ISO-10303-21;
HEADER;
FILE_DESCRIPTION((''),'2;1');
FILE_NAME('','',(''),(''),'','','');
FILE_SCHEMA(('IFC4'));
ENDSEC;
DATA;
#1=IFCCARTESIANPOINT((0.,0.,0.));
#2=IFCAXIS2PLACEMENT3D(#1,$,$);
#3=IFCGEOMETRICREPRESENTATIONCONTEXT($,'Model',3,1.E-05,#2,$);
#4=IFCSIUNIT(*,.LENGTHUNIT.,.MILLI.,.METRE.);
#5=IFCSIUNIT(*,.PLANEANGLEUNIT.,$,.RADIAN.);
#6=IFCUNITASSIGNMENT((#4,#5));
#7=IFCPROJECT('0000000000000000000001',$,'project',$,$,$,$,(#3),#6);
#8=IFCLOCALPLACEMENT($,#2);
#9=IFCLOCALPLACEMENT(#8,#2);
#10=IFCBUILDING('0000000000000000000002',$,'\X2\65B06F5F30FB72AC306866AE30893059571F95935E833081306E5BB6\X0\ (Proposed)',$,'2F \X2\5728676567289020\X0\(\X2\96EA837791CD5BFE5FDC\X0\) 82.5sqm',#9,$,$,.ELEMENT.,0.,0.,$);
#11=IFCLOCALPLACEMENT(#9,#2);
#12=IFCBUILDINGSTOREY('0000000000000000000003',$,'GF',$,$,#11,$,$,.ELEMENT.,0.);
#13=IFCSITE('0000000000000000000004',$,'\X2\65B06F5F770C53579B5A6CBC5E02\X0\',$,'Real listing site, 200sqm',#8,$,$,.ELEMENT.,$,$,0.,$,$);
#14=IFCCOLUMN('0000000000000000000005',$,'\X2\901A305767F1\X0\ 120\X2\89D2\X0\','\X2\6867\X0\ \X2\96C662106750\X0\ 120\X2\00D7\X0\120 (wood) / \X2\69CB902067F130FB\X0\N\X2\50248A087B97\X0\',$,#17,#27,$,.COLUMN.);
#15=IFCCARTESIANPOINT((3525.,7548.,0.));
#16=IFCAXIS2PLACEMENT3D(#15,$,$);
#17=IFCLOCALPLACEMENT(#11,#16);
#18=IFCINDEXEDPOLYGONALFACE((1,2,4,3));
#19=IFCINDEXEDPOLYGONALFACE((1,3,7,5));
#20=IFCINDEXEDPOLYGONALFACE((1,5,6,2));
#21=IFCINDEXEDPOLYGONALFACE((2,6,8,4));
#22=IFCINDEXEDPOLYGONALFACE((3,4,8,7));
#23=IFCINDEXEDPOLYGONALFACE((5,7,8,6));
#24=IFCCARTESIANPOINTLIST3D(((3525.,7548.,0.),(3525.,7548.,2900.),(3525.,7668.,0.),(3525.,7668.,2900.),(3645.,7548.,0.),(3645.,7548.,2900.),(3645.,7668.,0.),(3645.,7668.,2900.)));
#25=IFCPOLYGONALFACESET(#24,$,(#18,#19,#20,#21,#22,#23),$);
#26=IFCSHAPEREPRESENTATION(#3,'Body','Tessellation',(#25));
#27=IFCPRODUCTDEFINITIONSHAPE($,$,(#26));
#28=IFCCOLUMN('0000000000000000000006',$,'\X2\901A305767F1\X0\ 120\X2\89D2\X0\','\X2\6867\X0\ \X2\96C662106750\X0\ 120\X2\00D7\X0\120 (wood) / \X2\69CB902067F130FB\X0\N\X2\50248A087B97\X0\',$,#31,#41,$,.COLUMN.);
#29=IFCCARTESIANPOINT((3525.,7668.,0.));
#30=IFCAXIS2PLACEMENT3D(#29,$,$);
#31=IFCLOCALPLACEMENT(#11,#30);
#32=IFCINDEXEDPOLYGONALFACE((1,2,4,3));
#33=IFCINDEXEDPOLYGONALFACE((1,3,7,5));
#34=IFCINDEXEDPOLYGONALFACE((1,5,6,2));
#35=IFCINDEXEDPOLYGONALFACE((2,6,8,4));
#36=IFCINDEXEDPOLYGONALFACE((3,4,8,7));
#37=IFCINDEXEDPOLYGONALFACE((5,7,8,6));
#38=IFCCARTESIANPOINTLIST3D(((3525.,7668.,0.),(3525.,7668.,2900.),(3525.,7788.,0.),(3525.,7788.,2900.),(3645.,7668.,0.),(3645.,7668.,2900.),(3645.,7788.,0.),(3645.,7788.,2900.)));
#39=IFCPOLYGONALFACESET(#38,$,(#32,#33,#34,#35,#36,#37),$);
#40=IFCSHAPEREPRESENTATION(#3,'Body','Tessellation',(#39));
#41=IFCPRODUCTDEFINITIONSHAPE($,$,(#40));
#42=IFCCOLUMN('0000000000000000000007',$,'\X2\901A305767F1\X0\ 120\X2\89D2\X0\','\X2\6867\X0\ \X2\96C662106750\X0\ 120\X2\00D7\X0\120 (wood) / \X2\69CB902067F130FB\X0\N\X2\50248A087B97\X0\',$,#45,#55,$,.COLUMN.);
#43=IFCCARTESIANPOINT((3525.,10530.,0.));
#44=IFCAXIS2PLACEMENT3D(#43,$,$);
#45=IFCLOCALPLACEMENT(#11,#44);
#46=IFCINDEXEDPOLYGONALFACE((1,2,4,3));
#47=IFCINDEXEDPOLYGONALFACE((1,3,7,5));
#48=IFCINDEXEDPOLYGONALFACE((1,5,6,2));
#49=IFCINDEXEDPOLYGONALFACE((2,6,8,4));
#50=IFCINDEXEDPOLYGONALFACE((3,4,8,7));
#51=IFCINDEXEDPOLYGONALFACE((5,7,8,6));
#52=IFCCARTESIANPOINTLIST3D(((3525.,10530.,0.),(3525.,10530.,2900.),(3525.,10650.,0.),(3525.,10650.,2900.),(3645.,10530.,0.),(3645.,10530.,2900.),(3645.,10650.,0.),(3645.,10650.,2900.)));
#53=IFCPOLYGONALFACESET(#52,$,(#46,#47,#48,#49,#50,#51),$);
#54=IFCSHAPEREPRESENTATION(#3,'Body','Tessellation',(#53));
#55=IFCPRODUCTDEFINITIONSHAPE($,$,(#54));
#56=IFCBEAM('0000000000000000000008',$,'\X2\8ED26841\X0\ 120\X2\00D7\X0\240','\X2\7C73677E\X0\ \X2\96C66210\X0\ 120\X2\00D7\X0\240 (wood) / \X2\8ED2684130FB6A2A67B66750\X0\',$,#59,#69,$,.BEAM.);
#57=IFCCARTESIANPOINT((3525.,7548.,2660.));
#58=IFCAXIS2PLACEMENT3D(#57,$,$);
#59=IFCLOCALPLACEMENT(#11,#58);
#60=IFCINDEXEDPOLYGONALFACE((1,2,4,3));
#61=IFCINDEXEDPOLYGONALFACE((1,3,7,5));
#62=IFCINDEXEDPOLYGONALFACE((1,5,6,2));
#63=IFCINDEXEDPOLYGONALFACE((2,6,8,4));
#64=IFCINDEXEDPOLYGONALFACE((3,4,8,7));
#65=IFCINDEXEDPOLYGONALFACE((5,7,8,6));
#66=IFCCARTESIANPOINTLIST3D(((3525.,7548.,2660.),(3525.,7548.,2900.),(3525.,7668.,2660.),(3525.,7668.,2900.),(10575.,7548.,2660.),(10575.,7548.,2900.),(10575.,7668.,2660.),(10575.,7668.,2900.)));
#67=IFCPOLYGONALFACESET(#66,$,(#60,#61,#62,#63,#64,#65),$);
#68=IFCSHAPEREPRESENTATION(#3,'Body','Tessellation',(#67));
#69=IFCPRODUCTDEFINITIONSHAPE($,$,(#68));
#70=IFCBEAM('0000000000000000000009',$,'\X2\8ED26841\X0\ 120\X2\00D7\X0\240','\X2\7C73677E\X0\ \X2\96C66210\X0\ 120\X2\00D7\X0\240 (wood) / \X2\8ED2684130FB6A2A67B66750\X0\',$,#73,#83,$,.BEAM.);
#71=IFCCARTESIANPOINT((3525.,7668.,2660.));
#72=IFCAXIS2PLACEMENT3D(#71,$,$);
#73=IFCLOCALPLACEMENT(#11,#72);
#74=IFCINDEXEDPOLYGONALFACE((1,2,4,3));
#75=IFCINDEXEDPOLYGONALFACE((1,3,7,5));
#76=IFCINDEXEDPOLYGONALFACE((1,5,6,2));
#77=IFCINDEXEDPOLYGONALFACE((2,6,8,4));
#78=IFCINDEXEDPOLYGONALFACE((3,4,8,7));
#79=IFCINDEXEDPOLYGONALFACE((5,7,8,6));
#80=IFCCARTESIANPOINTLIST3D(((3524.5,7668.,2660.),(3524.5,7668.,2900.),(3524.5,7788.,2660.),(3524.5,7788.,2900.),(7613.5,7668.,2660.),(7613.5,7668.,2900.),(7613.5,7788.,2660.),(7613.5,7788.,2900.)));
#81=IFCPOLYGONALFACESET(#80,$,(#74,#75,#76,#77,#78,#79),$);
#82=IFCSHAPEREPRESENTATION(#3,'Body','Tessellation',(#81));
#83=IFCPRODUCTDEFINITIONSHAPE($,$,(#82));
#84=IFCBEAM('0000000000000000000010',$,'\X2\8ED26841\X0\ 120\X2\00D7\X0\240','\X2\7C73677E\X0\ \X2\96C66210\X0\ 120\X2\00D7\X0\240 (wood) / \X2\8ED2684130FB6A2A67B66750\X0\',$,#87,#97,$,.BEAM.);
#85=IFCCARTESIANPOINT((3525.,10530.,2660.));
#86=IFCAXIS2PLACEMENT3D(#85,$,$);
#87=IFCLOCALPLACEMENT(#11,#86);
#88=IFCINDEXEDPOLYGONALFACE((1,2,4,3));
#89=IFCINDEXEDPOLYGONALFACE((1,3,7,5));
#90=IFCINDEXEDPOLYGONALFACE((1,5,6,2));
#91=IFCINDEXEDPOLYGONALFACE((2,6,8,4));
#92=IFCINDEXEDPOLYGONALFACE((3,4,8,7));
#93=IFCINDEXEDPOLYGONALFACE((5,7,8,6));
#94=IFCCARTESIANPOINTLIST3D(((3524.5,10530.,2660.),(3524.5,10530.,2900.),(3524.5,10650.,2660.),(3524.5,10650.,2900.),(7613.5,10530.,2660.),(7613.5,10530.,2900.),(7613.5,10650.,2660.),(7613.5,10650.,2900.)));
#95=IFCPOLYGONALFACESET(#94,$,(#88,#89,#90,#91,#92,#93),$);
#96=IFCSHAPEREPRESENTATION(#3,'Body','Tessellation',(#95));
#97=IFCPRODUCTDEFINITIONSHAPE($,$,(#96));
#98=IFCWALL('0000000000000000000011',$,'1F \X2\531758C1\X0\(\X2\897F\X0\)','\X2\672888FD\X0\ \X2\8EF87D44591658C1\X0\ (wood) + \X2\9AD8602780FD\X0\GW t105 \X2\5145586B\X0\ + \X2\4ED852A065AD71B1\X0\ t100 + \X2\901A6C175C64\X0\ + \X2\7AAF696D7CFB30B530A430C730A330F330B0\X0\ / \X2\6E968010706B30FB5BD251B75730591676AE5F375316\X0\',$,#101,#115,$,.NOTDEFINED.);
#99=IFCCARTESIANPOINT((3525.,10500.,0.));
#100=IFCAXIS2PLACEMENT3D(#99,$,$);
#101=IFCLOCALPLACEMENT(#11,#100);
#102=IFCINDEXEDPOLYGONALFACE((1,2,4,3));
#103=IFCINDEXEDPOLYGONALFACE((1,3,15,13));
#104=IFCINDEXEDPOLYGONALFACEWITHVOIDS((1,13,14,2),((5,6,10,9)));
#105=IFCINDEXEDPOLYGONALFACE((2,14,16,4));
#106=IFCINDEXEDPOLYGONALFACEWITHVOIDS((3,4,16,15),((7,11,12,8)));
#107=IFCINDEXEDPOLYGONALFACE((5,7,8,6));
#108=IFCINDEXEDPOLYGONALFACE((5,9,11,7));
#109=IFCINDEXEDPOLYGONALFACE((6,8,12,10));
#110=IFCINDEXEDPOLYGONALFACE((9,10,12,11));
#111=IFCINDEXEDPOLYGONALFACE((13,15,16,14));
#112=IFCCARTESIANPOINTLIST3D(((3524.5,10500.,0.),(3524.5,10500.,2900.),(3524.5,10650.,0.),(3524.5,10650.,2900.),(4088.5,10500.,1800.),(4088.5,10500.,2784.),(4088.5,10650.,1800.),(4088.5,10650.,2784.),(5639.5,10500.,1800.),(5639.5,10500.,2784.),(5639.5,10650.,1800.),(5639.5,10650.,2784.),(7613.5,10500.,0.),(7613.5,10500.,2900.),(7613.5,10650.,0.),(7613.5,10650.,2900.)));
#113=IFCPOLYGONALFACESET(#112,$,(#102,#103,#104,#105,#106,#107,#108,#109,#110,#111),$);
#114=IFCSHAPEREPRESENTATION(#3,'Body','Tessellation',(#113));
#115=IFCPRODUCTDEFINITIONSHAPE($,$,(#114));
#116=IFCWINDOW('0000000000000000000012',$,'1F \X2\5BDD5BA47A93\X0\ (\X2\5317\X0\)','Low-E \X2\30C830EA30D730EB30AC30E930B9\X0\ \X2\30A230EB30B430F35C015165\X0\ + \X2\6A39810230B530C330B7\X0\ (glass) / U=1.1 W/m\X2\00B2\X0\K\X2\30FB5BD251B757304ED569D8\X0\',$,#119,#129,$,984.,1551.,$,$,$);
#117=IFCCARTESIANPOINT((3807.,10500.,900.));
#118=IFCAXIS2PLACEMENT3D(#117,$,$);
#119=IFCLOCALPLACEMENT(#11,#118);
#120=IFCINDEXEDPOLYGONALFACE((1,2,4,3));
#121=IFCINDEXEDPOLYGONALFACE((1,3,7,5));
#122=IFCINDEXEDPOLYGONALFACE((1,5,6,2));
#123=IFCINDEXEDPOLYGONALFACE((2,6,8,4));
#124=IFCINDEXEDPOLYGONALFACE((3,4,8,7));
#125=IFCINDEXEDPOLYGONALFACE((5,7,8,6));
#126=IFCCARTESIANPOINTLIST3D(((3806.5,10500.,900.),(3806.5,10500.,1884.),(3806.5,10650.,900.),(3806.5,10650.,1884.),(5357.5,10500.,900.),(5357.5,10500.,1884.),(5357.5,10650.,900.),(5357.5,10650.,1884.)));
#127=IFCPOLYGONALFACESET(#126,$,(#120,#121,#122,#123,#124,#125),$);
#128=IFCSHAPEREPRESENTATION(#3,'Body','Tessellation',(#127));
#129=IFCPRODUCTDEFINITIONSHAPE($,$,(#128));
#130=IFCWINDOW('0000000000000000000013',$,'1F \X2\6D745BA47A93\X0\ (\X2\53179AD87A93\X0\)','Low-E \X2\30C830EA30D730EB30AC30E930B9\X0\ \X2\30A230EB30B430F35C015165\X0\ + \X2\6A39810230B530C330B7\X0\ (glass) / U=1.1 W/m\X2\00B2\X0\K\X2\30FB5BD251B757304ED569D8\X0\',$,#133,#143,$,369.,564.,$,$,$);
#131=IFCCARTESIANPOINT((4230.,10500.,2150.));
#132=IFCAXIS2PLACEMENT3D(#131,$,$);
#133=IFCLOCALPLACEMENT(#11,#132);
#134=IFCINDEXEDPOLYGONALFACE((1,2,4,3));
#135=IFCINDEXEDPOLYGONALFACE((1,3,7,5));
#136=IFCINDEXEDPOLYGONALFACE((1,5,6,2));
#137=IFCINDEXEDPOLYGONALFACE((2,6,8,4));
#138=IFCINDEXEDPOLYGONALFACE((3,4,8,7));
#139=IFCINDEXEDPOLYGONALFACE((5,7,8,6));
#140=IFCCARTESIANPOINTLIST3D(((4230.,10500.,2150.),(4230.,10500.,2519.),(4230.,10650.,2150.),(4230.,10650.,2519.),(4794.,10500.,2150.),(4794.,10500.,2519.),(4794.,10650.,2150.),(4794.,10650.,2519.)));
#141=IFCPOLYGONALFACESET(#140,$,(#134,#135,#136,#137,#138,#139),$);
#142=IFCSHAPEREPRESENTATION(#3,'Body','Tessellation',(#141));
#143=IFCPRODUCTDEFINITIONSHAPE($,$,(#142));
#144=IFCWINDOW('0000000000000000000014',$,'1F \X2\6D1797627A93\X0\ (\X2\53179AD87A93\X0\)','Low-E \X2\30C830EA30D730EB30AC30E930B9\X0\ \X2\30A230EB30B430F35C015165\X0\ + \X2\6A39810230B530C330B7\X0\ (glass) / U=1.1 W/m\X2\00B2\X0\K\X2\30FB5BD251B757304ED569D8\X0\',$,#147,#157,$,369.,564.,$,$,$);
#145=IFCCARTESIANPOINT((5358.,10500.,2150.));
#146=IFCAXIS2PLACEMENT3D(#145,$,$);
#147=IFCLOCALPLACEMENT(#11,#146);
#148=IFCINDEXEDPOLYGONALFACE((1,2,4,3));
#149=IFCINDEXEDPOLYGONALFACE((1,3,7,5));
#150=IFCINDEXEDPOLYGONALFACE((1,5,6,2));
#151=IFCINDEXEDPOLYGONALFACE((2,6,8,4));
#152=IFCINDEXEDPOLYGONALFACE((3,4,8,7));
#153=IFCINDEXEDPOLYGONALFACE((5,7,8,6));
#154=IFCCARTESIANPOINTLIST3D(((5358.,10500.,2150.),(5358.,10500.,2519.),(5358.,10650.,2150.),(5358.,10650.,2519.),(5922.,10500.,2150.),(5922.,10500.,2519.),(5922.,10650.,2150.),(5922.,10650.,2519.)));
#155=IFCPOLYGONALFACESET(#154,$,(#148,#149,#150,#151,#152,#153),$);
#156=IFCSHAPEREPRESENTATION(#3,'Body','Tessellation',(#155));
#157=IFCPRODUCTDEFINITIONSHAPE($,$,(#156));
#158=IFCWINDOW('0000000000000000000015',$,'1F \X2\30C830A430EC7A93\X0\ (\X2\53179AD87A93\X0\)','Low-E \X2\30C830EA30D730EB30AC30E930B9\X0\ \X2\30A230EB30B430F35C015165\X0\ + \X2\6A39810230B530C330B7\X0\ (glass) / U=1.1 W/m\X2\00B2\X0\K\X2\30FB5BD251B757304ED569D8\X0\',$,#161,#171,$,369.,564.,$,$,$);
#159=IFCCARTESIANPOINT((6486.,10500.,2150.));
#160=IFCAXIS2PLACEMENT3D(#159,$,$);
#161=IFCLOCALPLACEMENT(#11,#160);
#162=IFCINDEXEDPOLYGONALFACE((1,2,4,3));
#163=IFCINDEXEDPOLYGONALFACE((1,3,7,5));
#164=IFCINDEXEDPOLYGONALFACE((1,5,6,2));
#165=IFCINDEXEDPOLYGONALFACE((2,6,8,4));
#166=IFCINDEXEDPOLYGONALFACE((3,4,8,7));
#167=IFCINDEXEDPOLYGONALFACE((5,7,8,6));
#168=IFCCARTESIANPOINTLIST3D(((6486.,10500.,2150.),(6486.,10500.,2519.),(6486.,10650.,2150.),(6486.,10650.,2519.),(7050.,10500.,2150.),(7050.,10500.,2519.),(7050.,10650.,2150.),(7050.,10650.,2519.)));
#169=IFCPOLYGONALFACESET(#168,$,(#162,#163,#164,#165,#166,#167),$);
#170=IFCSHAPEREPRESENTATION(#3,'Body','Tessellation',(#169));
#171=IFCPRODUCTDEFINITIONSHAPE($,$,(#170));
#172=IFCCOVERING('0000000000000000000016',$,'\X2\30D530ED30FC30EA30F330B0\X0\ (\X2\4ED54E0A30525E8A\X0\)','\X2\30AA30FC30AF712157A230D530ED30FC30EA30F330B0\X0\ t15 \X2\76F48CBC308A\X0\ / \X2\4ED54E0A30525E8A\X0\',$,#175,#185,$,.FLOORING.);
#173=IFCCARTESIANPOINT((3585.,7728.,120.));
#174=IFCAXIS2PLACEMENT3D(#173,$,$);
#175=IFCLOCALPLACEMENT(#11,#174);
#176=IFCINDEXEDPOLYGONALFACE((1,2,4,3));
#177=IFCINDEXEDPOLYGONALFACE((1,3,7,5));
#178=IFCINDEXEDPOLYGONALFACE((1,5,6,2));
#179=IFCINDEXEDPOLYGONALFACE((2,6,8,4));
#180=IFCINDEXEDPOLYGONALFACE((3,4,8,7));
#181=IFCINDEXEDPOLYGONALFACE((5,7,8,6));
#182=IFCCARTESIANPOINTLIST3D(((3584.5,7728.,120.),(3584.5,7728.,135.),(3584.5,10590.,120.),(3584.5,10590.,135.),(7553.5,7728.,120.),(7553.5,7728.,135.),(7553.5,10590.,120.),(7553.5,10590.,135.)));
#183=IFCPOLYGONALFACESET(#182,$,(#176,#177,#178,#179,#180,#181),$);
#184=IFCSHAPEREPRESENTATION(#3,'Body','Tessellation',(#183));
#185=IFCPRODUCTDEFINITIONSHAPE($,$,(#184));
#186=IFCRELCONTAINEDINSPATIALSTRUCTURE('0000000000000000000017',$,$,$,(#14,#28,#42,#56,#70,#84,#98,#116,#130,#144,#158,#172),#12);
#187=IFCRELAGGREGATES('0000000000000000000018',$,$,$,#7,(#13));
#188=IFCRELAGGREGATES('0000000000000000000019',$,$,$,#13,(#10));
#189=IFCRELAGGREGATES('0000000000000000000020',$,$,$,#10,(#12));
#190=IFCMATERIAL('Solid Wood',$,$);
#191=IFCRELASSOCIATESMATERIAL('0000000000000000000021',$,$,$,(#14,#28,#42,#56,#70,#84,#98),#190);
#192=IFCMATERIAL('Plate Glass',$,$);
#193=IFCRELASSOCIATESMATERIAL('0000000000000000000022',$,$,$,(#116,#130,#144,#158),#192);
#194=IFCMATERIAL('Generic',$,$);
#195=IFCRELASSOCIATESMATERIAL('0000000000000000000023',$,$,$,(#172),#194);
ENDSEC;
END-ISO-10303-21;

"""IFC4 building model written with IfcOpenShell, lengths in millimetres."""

from ifc_helpers import new_model, si_unit, frame, frame_2d, origin, place, context, project, spatial, rectangle, extrude, material, element, fill, save


model = new_model("IFC4")

# Units and contexts
model_context = context("Model", 3, precision=1e-05, world=origin())
ifc_project = project(units=[si_unit("LENGTHUNIT", "METRE", prefix="MILLI"), si_unit("PLANEANGLEUNIT", "RADIAN")], contexts=[model_context])

# Site, building, storey
site_placement = place(None, origin())
site = spatial("IfcSite", under=ifc_project, at=site_placement, Name="新潟県南魚沼市", ObjectType="Real listing site, 200sqm", CompositionType="ELEMENT", RefElevation=0.0)
building_placement = place(site_placement, origin())
building = spatial("IfcBuilding", under=site, at=building_placement, Name="新潟・犬と暮らす土間広めの家 (Proposed)", ObjectType="2F 在来木造(雪荷重対応) 82.5sqm", CompositionType="ELEMENT", ElevationOfRefHeight=0.0, ElevationOfTerrain=0.0)
storey_placement = place(building_placement, origin())
storey = spatial("IfcBuildingStorey", under=building, at=storey_placement, Name="GF", CompositionType="ELEMENT", Elevation=0.0)

# Columns
ifc_material_1 = material(Name="Solid Wood")
column_1_placement = place(storey_placement, frame((3525.0, 7548.0, 0.0)))
element("IfcColumn", 1, at=column_1_placement, inside=storey, material=ifc_material_1, Name="通し柱 120角", Description="桧 集成材 120×120 (wood) / 構造柱・N値計算", PredefinedType="COLUMN", context=model_context, shape_type="SweptSolid", body=[
    extrude(rectangle(XDim=120.0, YDim=120.0, at=frame_2d((60.0, 60.0))), frame((3525.0, 7548.0, 0.0)), (0.0, 0.0, 1.0), 2900.0),
])
column_2_placement = place(storey_placement, frame((3525.0, 7668.0, 0.0)))
element("IfcColumn", 2, at=column_2_placement, inside=storey, material=ifc_material_1, Name="通し柱 120角", Description="桧 集成材 120×120 (wood) / 構造柱・N値計算", PredefinedType="COLUMN", context=model_context, shape_type="SweptSolid", body=[
    extrude(rectangle(XDim=120.0, YDim=120.0, at=frame_2d((60.0, 60.0))), frame((3525.0, 7668.0, 0.0)), (0.0, 0.0, 1.0), 2900.0),
])
column_3_placement = place(storey_placement, frame((3525.0, 10530.0, 0.0)))
element("IfcColumn", 3, at=column_3_placement, inside=storey, material=ifc_material_1, Name="通し柱 120角", Description="桧 集成材 120×120 (wood) / 構造柱・N値計算", PredefinedType="COLUMN", context=model_context, shape_type="SweptSolid", body=[
    extrude(rectangle(XDim=120.0, YDim=120.0, at=frame_2d((60.0, 60.0))), frame((3525.0, 10530.0, 0.0)), (0.0, 0.0, 1.0), 2900.0),
])

# Beams
beam_1_placement = place(storey_placement, frame((3525.0, 7548.0, 2660.0)))
element("IfcBeam", 4, at=beam_1_placement, inside=storey, material=ifc_material_1, Name="軒桁 120×240", Description="米松 集成 120×240 (wood) / 軒桁・横架材", PredefinedType="BEAM", context=model_context, shape_type="SweptSolid", body=[
    extrude(rectangle(XDim=7050.0, YDim=120.0, at=frame_2d((3525.0, 60.0))), frame((3525.0, 7548.0, 2660.0)), (0.0, 0.0, 1.0), 240.0),
])
beam_2_placement = place(storey_placement, frame((3525.0, 7668.0, 2660.0)))
element("IfcBeam", 5, at=beam_2_placement, inside=storey, material=ifc_material_1, Name="軒桁 120×240", Description="米松 集成 120×240 (wood) / 軒桁・横架材", PredefinedType="BEAM", context=model_context, shape_type="SweptSolid", body=[
    extrude(rectangle(XDim=4089.0, YDim=120.0, at=frame_2d((2044.0, 60.0))), frame((3525.0, 7668.0, 2660.0)), (0.0, 0.0, 1.0), 240.0),
])
beam_3_placement = place(storey_placement, frame((3525.0, 10530.0, 2660.0)))
element("IfcBeam", 6, at=beam_3_placement, inside=storey, material=ifc_material_1, Name="軒桁 120×240", Description="米松 集成 120×240 (wood) / 軒桁・横架材", PredefinedType="BEAM", context=model_context, shape_type="SweptSolid", body=[
    extrude(rectangle(XDim=4089.0, YDim=120.0, at=frame_2d((2044.0, 60.0))), frame((3525.0, 10530.0, 2660.0)), (0.0, 0.0, 1.0), 240.0),
])

# Wall, openings, windows
wall_1_placement = place(storey_placement, frame((3525.0, 10500.0, 0.0)))
wall_1 = element("IfcWall", 7, at=wall_1_placement, inside=storey, material=ifc_material_1, Name="1F 北壁(西)", Description="木製 軸組外壁 (wood) + 高性能GW t105 充填 + 付加断熱 t100 + 通気層 + 窯業系サイディング / 準耐火・寒冷地外皮強化", PredefinedType="NOTDEFINED", context=model_context, shape_type="SweptSolid", body=[
    extrude(rectangle(XDim=4089.0, YDim=150.0, at=frame_2d((2044.0, 75.0))), frame((3525.0, 10500.0, 0.0)), (0.0, 0.0, 1.0), 2900.0),
])
opening_1_placement = place(storey_placement, frame((3807.0, 10500.0, 900.0)))
opening_1 = element("IfcOpeningElement", 8, at=opening_1_placement, cuts=wall_1, PredefinedType="NOTDEFINED", context=model_context, shape_type="SweptSolid", body=[
    extrude(rectangle(XDim=1551.0, YDim=150.0, at=frame_2d((775.0, 75.0))), frame((3807.0, 10500.0, 900.0)), (0.0, 0.0, 1.0), 984.0),
])
opening_2_placement = place(storey_placement, frame((4230.0, 10500.0, 2150.0)))
opening_2 = element("IfcOpeningElement", 9, at=opening_2_placement, cuts=wall_1, PredefinedType="NOTDEFINED", context=model_context, shape_type="SweptSolid", body=[
    extrude(rectangle(XDim=564.0, YDim=150.0, at=frame_2d((282.0, 75.0))), frame((4230.0, 10500.0, 2150.0)), (0.0, 0.0, 1.0), 369.0),
])
opening_3_placement = place(storey_placement, frame((5358.0, 10500.0, 2150.0)))
opening_3 = element("IfcOpeningElement", 10, at=opening_3_placement, cuts=wall_1, PredefinedType="NOTDEFINED", context=model_context, shape_type="SweptSolid", body=[
    extrude(rectangle(XDim=564.0, YDim=150.0, at=frame_2d((282.0, 75.0))), frame((5358.0, 10500.0, 2150.0)), (0.0, 0.0, 1.0), 369.0),
])
opening_4_placement = place(storey_placement, frame((6486.0, 10500.0, 2150.0)))
opening_4 = element("IfcOpeningElement", 11, at=opening_4_placement, cuts=wall_1, PredefinedType="NOTDEFINED", context=model_context, shape_type="SweptSolid", body=[
    extrude(rectangle(XDim=564.0, YDim=150.0, at=frame_2d((282.0, 75.0))), frame((6486.0, 10500.0, 2150.0)), (0.0, 0.0, 1.0), 369.0),
])
ifc_material_2 = material(Name="Plate Glass")
window_1_placement = place(storey_placement, frame((3807.0, 10500.0, 900.0)))
window_1 = element("IfcWindow", 12, at=window_1_placement, inside=storey, material=ifc_material_2, Name="1F 寝室窓 (北)", Description="Low-E トリプルガラス アルゴン封入 + 樹脂サッシ (glass) / U=1.1 W/m²K・寒冷地仕様", OverallHeight=984.0, OverallWidth=1551.0, context=model_context, shape_type="SweptSolid", body=[
    extrude(rectangle(XDim=1551.0, YDim=150.0, at=frame_2d((775.0, 75.0))), frame((3807.0, 10500.0, 900.0)), (0.0, 0.0, 1.0), 984.0),
])
fill(opening_1, window_1)
window_2_placement = place(storey_placement, frame((4230.0, 10500.0, 2150.0)))
window_2 = element("IfcWindow", 13, at=window_2_placement, inside=storey, material=ifc_material_2, Name="1F 浴室窓 (北高窓)", Description="Low-E トリプルガラス アルゴン封入 + 樹脂サッシ (glass) / U=1.1 W/m²K・寒冷地仕様", OverallHeight=369.0, OverallWidth=564.0, context=model_context, shape_type="SweptSolid", body=[
    extrude(rectangle(XDim=564.0, YDim=150.0, at=frame_2d((282.0, 75.0))), frame((4230.0, 10500.0, 2150.0)), (0.0, 0.0, 1.0), 369.0),
])
fill(opening_2, window_2)
window_3_placement = place(storey_placement, frame((5358.0, 10500.0, 2150.0)))
window_3 = element("IfcWindow", 14, at=window_3_placement, inside=storey, material=ifc_material_2, Name="1F 洗面窓 (北高窓)", Description="Low-E トリプルガラス アルゴン封入 + 樹脂サッシ (glass) / U=1.1 W/m²K・寒冷地仕様", OverallHeight=369.0, OverallWidth=564.0, context=model_context, shape_type="SweptSolid", body=[
    extrude(rectangle(XDim=564.0, YDim=150.0, at=frame_2d((282.0, 75.0))), frame((5358.0, 10500.0, 2150.0)), (0.0, 0.0, 1.0), 369.0),
])
fill(opening_3, window_3)
window_4_placement = place(storey_placement, frame((6486.0, 10500.0, 2150.0)))
window_4 = element("IfcWindow", 15, at=window_4_placement, inside=storey, material=ifc_material_2, Name="1F トイレ窓 (北高窓)", Description="Low-E トリプルガラス アルゴン封入 + 樹脂サッシ (glass) / U=1.1 W/m²K・寒冷地仕様", OverallHeight=369.0, OverallWidth=564.0, context=model_context, shape_type="SweptSolid", body=[
    extrude(rectangle(XDim=564.0, YDim=150.0, at=frame_2d((282.0, 75.0))), frame((6486.0, 10500.0, 2150.0)), (0.0, 0.0, 1.0), 369.0),
])
fill(opening_4, window_4)

# Covering
ifc_material_3 = material(Name="Generic")
covering_placement = place(storey_placement, frame((3585.0, 7728.0, 120.0)))
element("IfcCovering", 16, at=covering_placement, inside=storey, material=ifc_material_3, Name="フローリング (仕上げ床)", Description="オーク無垢フローリング t15 直貼り / 仕上げ床", PredefinedType="FLOORING", context=model_context, shape_type="SweptSolid", body=[
    extrude(rectangle(XDim=3969.0, YDim=2862.0, at=frame_2d((1984.0, 1431.0))), frame((3585.0, 7728.0, 120.0)), (0.0, 0.0, 1.0), 15.0),
])

save(model, "model.ifc")
